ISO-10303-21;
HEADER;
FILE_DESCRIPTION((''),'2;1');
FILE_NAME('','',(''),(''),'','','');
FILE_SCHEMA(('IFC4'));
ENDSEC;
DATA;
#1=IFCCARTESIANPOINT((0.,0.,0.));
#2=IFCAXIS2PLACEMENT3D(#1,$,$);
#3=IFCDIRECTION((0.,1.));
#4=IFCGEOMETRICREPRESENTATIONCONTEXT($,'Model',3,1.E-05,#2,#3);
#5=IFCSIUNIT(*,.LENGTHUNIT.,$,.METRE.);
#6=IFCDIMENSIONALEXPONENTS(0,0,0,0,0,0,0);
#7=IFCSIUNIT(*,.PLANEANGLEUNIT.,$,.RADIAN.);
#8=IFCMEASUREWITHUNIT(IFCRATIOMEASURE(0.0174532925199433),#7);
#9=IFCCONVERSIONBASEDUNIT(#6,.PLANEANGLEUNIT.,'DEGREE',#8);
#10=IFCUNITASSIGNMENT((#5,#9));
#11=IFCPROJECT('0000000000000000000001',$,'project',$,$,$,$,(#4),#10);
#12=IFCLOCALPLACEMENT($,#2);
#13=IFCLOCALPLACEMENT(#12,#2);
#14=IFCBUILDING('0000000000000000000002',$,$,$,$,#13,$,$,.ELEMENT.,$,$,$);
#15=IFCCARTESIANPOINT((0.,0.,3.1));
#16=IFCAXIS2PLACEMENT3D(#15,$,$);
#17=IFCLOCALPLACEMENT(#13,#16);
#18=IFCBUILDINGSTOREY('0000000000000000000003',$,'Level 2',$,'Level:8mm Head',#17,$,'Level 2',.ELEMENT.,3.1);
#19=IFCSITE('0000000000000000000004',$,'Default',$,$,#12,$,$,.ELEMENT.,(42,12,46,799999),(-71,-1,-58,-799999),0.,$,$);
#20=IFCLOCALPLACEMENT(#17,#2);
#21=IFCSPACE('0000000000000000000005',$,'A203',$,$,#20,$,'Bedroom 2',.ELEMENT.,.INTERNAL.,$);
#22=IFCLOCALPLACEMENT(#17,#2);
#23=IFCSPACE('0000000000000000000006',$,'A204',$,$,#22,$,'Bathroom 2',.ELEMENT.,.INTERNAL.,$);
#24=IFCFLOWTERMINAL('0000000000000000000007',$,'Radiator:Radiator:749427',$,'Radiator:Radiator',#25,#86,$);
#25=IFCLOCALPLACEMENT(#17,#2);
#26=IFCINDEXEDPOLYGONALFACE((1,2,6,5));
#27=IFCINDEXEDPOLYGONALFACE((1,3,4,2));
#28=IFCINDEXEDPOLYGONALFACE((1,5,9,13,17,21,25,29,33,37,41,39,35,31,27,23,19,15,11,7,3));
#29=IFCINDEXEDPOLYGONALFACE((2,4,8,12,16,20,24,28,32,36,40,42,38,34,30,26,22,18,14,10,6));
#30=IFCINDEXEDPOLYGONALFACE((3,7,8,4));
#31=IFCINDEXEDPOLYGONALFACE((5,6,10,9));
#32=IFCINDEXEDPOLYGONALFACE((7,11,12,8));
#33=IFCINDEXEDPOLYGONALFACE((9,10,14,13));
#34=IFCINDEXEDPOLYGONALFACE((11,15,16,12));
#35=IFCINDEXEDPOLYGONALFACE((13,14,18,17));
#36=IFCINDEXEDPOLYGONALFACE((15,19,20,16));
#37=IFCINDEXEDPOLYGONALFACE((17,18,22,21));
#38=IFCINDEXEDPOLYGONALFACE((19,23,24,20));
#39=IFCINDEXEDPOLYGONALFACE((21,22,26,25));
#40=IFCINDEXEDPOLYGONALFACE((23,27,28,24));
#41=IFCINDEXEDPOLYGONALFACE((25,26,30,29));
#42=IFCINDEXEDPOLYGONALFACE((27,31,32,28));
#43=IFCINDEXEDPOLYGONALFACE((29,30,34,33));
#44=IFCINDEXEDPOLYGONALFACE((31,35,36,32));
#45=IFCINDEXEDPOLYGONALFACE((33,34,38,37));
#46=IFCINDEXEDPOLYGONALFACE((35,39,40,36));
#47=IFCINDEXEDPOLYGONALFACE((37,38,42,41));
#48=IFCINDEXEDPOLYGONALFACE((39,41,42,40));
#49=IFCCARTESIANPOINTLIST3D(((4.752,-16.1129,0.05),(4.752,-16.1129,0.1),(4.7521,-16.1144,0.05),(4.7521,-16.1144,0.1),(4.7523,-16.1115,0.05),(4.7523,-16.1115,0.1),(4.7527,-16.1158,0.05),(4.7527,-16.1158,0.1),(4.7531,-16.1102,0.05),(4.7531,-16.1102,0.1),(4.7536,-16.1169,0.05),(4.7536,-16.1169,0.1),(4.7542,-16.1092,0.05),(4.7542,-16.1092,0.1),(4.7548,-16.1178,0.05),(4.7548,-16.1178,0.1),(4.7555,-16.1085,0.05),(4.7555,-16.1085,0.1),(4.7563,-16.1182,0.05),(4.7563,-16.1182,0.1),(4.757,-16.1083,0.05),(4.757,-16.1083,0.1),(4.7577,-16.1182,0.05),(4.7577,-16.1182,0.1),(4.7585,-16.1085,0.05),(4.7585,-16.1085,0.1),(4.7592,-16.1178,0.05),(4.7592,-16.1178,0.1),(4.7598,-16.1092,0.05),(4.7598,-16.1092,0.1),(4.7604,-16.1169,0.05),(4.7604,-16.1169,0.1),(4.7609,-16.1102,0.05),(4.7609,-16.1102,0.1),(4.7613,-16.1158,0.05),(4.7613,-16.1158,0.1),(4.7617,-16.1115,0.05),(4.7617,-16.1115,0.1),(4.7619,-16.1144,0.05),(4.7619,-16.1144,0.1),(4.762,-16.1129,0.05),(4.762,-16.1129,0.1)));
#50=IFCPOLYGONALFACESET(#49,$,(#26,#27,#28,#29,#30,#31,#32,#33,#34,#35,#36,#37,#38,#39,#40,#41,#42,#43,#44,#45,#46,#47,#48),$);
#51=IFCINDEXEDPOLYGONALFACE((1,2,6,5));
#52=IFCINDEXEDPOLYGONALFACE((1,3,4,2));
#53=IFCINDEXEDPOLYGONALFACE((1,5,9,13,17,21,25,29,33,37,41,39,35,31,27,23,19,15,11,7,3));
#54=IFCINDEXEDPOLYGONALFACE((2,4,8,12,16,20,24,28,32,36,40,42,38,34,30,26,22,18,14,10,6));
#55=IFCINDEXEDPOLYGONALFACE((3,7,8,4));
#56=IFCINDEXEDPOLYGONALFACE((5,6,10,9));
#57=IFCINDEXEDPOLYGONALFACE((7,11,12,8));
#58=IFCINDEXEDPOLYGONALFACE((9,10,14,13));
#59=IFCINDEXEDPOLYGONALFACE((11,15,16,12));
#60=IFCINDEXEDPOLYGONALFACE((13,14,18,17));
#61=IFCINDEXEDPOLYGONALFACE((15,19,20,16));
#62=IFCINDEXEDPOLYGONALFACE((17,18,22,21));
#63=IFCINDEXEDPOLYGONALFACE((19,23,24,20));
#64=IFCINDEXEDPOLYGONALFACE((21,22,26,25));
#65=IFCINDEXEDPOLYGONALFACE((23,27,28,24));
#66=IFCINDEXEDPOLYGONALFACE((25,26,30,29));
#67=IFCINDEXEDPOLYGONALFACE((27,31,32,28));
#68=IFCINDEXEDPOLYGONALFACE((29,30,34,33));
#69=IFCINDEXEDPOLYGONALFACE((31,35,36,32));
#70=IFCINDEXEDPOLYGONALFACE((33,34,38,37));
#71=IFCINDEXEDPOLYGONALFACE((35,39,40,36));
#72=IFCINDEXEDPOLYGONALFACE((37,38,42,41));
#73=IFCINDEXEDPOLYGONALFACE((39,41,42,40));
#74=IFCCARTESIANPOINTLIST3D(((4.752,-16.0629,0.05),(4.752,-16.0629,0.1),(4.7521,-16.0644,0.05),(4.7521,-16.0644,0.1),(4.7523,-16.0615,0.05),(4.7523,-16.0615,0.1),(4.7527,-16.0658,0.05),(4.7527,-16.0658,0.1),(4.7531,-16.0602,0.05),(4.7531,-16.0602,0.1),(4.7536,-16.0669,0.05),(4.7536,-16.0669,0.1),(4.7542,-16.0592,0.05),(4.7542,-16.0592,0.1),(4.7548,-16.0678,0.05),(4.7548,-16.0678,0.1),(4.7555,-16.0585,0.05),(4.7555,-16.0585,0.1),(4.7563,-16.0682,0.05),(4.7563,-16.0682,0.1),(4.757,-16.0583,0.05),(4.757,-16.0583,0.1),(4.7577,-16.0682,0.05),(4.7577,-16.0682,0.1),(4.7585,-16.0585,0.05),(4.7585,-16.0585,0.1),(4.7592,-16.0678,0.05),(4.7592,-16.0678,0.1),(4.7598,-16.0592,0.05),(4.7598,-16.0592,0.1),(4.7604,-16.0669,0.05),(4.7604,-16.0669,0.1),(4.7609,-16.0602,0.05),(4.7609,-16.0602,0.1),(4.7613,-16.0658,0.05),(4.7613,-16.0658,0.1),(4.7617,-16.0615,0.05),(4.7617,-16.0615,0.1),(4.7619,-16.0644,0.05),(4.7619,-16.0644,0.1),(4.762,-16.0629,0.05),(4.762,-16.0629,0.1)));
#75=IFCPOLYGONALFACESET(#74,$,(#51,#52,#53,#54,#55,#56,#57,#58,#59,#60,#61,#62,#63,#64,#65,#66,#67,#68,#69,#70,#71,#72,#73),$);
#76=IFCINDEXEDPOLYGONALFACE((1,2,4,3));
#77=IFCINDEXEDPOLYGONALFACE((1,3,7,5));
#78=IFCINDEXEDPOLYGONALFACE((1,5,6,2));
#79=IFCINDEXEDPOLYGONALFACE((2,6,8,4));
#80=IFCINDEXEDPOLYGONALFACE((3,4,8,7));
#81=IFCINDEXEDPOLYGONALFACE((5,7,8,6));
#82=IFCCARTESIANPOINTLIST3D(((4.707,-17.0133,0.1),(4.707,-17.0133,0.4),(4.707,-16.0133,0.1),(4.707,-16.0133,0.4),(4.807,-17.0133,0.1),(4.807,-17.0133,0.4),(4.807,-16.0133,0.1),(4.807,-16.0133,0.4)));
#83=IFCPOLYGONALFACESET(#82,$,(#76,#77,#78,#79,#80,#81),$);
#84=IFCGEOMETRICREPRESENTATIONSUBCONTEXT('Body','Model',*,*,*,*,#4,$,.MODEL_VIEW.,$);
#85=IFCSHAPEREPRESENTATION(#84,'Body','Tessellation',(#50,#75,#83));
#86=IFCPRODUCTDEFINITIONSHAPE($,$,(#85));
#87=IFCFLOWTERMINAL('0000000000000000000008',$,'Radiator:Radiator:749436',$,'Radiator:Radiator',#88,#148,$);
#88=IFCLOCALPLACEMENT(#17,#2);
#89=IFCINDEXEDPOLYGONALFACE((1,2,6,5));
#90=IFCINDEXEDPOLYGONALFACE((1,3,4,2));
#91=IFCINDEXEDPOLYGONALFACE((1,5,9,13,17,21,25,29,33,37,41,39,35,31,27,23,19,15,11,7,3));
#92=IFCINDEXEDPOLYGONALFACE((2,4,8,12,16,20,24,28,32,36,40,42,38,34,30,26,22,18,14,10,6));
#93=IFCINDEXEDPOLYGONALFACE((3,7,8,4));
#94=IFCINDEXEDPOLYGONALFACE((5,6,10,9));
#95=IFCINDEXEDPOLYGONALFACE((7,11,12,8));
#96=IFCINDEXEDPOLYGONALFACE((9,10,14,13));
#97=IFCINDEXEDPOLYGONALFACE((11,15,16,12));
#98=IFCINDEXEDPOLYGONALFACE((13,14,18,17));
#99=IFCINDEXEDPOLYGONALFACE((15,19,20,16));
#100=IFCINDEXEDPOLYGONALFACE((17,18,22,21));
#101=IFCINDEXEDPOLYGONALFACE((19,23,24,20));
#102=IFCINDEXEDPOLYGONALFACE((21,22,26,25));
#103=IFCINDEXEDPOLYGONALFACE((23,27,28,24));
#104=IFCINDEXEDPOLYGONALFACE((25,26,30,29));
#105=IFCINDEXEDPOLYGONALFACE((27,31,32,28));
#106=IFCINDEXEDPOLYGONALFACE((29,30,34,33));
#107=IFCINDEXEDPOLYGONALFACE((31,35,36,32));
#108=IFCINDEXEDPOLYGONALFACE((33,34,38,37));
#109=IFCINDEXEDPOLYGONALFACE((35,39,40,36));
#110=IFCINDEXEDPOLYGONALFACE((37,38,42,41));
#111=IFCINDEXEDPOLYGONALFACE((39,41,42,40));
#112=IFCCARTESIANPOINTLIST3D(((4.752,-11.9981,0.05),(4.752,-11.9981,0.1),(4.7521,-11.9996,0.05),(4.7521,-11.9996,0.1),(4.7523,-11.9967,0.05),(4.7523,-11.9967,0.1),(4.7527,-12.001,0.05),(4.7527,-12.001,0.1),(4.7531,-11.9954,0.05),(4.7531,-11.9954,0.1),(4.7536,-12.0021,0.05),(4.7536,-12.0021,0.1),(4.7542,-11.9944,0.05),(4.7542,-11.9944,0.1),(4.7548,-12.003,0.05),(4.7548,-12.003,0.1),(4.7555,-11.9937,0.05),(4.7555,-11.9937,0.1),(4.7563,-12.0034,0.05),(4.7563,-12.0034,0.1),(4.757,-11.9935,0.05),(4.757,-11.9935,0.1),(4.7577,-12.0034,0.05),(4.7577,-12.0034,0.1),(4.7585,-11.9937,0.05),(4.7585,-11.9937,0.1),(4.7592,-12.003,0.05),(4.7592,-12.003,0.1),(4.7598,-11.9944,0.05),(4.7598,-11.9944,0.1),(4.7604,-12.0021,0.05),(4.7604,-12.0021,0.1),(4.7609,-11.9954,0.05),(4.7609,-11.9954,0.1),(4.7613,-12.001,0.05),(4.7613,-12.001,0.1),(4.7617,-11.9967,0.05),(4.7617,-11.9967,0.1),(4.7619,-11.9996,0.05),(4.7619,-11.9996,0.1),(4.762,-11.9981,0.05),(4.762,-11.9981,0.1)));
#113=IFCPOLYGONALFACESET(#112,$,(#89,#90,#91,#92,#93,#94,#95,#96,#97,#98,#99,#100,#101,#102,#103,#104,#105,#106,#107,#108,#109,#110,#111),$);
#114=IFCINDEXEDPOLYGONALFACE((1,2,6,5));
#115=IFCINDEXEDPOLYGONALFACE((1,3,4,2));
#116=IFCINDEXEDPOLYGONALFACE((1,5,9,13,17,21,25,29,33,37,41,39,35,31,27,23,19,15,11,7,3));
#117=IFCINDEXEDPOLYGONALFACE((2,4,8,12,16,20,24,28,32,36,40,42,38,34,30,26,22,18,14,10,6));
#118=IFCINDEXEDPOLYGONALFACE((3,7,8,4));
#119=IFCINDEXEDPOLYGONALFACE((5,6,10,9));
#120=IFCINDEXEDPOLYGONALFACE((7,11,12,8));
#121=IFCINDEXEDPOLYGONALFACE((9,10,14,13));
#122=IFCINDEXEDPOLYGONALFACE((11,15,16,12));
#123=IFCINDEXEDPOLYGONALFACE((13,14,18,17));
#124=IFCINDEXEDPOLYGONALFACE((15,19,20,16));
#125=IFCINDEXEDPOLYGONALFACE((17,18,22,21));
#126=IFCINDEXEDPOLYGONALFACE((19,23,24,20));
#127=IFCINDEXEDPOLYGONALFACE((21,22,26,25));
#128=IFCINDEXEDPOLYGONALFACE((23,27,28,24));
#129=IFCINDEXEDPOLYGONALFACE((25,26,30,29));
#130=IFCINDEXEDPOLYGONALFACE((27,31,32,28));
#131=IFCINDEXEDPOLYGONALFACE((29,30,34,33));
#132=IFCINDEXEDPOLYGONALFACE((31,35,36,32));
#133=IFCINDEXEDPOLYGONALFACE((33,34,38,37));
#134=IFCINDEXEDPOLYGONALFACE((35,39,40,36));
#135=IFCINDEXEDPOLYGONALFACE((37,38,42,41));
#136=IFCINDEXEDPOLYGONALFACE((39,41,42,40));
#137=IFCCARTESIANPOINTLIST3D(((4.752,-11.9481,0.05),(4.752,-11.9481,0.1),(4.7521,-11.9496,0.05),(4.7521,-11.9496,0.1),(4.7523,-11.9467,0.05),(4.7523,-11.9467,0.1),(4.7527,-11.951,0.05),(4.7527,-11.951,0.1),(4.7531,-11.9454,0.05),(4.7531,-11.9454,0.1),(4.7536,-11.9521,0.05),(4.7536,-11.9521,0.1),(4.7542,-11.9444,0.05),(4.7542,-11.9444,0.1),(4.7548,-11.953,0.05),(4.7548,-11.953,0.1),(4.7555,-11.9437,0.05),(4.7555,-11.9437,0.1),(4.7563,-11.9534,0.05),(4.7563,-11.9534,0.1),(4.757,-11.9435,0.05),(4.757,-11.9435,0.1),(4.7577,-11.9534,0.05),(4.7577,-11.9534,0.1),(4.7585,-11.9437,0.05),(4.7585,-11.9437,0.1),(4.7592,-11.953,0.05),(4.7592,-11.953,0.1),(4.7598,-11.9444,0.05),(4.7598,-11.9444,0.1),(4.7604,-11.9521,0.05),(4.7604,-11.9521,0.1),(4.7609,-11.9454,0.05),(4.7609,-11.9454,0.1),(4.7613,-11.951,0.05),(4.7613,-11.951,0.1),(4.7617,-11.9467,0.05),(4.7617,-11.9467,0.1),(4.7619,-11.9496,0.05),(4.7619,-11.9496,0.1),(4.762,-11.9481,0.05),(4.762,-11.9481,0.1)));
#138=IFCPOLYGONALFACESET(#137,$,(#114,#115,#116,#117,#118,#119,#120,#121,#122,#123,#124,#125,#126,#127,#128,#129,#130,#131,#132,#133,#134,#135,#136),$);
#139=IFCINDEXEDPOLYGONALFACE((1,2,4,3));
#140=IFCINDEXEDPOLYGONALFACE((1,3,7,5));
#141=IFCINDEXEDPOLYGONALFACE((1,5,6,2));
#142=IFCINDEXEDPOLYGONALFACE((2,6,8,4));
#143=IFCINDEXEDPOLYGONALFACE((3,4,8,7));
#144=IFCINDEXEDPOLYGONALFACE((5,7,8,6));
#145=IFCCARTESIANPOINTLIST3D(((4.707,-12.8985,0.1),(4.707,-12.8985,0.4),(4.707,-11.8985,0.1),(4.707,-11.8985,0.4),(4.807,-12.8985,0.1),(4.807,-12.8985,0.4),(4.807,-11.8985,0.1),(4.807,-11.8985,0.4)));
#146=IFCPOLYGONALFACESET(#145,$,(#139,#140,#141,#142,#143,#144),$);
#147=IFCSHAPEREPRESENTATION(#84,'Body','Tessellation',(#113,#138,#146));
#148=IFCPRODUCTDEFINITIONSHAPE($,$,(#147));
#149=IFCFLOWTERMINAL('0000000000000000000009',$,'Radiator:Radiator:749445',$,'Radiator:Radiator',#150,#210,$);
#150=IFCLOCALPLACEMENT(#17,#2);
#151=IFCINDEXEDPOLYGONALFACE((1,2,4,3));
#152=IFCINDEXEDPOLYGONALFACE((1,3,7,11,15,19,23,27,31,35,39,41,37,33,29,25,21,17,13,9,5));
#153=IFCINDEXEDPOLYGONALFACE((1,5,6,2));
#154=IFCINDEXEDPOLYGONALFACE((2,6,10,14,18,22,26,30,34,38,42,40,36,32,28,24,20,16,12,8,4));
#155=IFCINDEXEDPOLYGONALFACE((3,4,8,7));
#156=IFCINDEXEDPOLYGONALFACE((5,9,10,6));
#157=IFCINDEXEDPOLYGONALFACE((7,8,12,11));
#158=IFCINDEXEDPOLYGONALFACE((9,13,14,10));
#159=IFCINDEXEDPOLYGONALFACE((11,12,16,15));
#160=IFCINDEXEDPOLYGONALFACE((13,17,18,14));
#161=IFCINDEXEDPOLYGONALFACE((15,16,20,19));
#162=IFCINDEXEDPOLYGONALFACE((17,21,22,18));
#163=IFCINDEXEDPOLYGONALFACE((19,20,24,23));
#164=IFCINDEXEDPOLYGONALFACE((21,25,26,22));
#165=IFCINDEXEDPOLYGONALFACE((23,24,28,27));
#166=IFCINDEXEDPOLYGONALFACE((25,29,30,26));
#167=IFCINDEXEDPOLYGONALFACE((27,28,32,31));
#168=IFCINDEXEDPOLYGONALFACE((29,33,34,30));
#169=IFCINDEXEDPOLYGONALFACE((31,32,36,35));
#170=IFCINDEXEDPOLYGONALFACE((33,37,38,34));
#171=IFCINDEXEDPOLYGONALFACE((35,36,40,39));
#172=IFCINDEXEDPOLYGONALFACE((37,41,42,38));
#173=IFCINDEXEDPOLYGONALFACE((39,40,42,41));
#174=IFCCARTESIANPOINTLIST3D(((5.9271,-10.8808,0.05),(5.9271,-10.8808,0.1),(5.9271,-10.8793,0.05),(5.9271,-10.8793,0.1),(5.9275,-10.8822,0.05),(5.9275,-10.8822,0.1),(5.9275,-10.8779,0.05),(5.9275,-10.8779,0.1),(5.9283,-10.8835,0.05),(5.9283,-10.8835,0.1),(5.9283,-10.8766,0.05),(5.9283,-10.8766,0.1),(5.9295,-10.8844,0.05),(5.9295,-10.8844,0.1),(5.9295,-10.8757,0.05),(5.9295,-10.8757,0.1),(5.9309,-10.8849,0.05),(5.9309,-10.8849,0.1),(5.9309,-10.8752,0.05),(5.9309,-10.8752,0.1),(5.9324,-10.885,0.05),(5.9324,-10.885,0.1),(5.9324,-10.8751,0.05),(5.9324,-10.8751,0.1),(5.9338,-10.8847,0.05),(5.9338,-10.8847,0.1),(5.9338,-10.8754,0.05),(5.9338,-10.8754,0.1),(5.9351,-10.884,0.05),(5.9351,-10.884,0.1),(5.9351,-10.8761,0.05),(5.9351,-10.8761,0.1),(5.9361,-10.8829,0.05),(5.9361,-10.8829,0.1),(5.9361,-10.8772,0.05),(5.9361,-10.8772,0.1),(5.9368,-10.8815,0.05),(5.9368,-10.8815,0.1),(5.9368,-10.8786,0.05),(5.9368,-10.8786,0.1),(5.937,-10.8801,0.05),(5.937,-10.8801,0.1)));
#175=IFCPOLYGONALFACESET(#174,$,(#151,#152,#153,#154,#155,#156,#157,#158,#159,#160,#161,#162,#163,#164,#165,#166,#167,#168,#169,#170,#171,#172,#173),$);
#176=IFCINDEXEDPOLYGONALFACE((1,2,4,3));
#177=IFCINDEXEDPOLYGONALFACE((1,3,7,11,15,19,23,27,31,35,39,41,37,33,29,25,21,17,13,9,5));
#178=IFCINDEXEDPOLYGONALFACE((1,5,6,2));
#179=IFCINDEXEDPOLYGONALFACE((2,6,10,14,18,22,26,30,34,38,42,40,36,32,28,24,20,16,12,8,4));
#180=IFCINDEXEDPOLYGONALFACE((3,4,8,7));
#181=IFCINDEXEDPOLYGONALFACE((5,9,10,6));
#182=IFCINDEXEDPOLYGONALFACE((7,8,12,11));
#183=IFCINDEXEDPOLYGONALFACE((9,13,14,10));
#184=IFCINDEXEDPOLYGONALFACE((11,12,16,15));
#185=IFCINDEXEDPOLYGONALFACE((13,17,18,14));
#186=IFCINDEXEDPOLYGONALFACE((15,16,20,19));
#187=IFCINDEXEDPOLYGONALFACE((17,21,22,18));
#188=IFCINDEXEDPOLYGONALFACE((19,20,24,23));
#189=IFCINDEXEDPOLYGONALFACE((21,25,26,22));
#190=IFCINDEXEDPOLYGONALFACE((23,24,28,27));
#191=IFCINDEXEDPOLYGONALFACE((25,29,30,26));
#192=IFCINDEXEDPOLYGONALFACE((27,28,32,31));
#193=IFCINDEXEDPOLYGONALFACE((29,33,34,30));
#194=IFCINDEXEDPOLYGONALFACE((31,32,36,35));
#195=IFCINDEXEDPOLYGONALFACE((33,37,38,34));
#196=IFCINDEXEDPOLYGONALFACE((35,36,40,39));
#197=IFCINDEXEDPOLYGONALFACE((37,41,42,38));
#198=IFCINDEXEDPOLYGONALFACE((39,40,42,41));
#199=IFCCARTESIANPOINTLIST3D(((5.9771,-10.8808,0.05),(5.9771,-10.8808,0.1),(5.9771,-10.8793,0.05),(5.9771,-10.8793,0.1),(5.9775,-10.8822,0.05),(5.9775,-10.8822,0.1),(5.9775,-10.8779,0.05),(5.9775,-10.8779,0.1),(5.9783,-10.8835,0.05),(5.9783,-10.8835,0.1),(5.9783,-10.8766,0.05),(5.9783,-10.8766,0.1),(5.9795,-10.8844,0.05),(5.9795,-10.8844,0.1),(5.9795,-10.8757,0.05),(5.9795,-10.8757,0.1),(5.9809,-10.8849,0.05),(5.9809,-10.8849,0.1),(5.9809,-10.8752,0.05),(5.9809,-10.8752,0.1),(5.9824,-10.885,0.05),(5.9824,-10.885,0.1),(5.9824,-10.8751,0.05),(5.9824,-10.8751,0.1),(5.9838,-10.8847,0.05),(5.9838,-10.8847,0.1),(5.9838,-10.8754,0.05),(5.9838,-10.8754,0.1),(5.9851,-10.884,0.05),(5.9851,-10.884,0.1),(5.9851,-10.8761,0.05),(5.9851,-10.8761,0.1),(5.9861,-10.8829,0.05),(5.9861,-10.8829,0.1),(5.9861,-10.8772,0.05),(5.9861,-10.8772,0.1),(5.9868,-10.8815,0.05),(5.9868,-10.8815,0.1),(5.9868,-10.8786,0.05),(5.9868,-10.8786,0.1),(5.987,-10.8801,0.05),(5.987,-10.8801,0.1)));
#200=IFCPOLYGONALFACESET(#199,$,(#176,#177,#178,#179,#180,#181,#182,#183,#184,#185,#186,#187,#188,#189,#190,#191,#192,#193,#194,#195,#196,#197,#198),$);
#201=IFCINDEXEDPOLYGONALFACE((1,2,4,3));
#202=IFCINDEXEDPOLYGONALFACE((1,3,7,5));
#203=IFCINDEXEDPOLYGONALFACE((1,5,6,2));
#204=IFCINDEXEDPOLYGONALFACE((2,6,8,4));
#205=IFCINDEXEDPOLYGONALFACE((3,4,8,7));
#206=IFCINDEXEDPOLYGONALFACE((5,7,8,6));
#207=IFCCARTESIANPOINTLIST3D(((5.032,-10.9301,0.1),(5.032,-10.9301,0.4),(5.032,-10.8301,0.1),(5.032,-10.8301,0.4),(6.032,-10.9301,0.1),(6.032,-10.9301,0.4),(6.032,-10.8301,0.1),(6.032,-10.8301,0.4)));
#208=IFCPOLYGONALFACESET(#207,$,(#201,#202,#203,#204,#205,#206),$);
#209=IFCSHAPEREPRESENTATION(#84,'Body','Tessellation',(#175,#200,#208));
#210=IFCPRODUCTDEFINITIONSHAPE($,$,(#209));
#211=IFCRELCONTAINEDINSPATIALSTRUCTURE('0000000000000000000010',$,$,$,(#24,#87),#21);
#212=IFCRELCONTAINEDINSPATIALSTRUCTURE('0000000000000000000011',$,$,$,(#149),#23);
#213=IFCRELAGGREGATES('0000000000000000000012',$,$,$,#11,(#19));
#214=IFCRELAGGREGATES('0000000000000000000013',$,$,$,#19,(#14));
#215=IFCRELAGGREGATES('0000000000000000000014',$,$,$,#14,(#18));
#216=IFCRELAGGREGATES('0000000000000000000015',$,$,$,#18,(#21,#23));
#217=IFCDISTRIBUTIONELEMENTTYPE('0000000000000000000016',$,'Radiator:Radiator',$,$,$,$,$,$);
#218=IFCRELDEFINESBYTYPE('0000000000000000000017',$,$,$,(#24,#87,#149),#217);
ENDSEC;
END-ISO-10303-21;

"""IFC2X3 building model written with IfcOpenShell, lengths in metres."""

from ifc_helpers import new_model, entity, si_unit, converted_unit, direction, frame, frame_2d, origin, origin_2d_with_axis, place, context, subcontext, project, spatial, rectangle, circle, extrude, source, transform, mapped, type_object, type_shapes, element, save


model = new_model("IFC2X3")

# Units and contexts
model_context = context("Model", 3, precision=1e-05, world=origin(), true_north=direction((0.0, 1.0)))
body_context = subcontext(model_context, "Body", "Model", "MODEL_VIEW")
ifc_project = project(units=[si_unit("LENGTHUNIT", "METRE"), converted_unit("PLANEANGLEUNIT", "DEGREE", entity("IfcRatioMeasure", 0.0174532925199433), si_unit("PLANEANGLEUNIT", "RADIAN"), dimensions=[0, 0, 0, 0, 0, 0, 0])], contexts=[model_context])

# Site, building, storey, space
site_placement = place(None, origin())
site = spatial("IfcSite", under=ifc_project, at=site_placement, Name="Default", CompositionType="ELEMENT", RefLatitude=(42, 12, 46, 799999), RefLongitude=(-71, -1, -58, -799999), RefElevation=0.0)
building_placement = place(site_placement, origin())
building = spatial("IfcBuilding", under=site, at=building_placement, CompositionType="ELEMENT")
storey_placement = place(building_placement, frame((0.0, 0.0, 3.1)))
storey = spatial("IfcBuildingStorey", under=building, at=storey_placement, Name="Level 2", ObjectType="Level:8mm Head", LongName="Level 2", CompositionType="ELEMENT", Elevation=3.1)
space_1_placement = place(storey_placement, origin())
space_1 = spatial("IfcSpace", under=storey, at=space_1_placement, Name="A203", LongName="Bedroom 2", CompositionType="ELEMENT", InteriorOrExteriorSpace="INTERNAL")

# Flow terminals
distribution_element_type = type_object("IfcDistributionElementType", Name="Radiator:Radiator")
shared_shape = source(origin(), body_context, "Body", "SweptSolid", [
    extrude(circle(Radius=0.005, at=frame_2d((0.0, 0.0), x_axis=(1.0, 0.0))), frame((0.4, 0.0, -0.05)), (0.0, 0.0, 1.0), 0.05),
    extrude(circle(Radius=0.005, at=frame_2d((0.0, 0.0), x_axis=(1.0, 0.0))), frame((0.45, 0.0, -0.05)), (0.0, 0.0, 1.0), 0.05),
    extrude(rectangle(XDim=1.0, YDim=0.1, at=origin_2d_with_axis()), frame((0.0, 0.0, 0.0), z_axis=(0.0, 0.0, 1.0), x_axis=(-1.0, 0.0, 0.0)), (0.0, 0.0, 1.0), 0.3),
])
type_shapes(distribution_element_type, [shared_shape])
for number, where, z_axis, x_axis, name in (
    (1, (4.757, -16.5133, 0.1), (0.0, 0.0, 1.0), (0.0, 1.0, 0.0), "Radiator:Radiator:749427"),
    (2, (4.757, -12.3985, 0.1), (0.0, 0.0, 1.0), (0.0, 1.0, 0.0), "Radiator:Radiator:749436"),
):
    element("IfcFlowTerminal", number, at=place(space_1_placement, frame(where, z_axis=z_axis, x_axis=x_axis)), inside=space_1, type_object=distribution_element_type, Name=name, ObjectType="Radiator:Radiator", context=body_context, shape_type="MappedRepresentation", body=[
        mapped(shared_shape, transform((0.0, 0.0, 0.0), scale=1.0)),
    ])

# Shared definitions
space_2_placement = place(storey_placement, origin())
space_2 = spatial("IfcSpace", under=storey, at=space_2_placement, Name="A204", LongName="Bathroom 2", CompositionType="ELEMENT", InteriorOrExteriorSpace="INTERNAL")

# Flow terminal
flow_terminal_1_placement = place(space_2_placement, frame((5.532, -10.8801, 0.1)))
element("IfcFlowTerminal", 3, at=flow_terminal_1_placement, inside=space_2, type_object=distribution_element_type, Name="Radiator:Radiator:749445", ObjectType="Radiator:Radiator", context=body_context, shape_type="MappedRepresentation", body=[
    mapped(shared_shape, transform((0.0, 0.0, 0.0), scale=1.0)),
])

save(model, "model.ifc")
